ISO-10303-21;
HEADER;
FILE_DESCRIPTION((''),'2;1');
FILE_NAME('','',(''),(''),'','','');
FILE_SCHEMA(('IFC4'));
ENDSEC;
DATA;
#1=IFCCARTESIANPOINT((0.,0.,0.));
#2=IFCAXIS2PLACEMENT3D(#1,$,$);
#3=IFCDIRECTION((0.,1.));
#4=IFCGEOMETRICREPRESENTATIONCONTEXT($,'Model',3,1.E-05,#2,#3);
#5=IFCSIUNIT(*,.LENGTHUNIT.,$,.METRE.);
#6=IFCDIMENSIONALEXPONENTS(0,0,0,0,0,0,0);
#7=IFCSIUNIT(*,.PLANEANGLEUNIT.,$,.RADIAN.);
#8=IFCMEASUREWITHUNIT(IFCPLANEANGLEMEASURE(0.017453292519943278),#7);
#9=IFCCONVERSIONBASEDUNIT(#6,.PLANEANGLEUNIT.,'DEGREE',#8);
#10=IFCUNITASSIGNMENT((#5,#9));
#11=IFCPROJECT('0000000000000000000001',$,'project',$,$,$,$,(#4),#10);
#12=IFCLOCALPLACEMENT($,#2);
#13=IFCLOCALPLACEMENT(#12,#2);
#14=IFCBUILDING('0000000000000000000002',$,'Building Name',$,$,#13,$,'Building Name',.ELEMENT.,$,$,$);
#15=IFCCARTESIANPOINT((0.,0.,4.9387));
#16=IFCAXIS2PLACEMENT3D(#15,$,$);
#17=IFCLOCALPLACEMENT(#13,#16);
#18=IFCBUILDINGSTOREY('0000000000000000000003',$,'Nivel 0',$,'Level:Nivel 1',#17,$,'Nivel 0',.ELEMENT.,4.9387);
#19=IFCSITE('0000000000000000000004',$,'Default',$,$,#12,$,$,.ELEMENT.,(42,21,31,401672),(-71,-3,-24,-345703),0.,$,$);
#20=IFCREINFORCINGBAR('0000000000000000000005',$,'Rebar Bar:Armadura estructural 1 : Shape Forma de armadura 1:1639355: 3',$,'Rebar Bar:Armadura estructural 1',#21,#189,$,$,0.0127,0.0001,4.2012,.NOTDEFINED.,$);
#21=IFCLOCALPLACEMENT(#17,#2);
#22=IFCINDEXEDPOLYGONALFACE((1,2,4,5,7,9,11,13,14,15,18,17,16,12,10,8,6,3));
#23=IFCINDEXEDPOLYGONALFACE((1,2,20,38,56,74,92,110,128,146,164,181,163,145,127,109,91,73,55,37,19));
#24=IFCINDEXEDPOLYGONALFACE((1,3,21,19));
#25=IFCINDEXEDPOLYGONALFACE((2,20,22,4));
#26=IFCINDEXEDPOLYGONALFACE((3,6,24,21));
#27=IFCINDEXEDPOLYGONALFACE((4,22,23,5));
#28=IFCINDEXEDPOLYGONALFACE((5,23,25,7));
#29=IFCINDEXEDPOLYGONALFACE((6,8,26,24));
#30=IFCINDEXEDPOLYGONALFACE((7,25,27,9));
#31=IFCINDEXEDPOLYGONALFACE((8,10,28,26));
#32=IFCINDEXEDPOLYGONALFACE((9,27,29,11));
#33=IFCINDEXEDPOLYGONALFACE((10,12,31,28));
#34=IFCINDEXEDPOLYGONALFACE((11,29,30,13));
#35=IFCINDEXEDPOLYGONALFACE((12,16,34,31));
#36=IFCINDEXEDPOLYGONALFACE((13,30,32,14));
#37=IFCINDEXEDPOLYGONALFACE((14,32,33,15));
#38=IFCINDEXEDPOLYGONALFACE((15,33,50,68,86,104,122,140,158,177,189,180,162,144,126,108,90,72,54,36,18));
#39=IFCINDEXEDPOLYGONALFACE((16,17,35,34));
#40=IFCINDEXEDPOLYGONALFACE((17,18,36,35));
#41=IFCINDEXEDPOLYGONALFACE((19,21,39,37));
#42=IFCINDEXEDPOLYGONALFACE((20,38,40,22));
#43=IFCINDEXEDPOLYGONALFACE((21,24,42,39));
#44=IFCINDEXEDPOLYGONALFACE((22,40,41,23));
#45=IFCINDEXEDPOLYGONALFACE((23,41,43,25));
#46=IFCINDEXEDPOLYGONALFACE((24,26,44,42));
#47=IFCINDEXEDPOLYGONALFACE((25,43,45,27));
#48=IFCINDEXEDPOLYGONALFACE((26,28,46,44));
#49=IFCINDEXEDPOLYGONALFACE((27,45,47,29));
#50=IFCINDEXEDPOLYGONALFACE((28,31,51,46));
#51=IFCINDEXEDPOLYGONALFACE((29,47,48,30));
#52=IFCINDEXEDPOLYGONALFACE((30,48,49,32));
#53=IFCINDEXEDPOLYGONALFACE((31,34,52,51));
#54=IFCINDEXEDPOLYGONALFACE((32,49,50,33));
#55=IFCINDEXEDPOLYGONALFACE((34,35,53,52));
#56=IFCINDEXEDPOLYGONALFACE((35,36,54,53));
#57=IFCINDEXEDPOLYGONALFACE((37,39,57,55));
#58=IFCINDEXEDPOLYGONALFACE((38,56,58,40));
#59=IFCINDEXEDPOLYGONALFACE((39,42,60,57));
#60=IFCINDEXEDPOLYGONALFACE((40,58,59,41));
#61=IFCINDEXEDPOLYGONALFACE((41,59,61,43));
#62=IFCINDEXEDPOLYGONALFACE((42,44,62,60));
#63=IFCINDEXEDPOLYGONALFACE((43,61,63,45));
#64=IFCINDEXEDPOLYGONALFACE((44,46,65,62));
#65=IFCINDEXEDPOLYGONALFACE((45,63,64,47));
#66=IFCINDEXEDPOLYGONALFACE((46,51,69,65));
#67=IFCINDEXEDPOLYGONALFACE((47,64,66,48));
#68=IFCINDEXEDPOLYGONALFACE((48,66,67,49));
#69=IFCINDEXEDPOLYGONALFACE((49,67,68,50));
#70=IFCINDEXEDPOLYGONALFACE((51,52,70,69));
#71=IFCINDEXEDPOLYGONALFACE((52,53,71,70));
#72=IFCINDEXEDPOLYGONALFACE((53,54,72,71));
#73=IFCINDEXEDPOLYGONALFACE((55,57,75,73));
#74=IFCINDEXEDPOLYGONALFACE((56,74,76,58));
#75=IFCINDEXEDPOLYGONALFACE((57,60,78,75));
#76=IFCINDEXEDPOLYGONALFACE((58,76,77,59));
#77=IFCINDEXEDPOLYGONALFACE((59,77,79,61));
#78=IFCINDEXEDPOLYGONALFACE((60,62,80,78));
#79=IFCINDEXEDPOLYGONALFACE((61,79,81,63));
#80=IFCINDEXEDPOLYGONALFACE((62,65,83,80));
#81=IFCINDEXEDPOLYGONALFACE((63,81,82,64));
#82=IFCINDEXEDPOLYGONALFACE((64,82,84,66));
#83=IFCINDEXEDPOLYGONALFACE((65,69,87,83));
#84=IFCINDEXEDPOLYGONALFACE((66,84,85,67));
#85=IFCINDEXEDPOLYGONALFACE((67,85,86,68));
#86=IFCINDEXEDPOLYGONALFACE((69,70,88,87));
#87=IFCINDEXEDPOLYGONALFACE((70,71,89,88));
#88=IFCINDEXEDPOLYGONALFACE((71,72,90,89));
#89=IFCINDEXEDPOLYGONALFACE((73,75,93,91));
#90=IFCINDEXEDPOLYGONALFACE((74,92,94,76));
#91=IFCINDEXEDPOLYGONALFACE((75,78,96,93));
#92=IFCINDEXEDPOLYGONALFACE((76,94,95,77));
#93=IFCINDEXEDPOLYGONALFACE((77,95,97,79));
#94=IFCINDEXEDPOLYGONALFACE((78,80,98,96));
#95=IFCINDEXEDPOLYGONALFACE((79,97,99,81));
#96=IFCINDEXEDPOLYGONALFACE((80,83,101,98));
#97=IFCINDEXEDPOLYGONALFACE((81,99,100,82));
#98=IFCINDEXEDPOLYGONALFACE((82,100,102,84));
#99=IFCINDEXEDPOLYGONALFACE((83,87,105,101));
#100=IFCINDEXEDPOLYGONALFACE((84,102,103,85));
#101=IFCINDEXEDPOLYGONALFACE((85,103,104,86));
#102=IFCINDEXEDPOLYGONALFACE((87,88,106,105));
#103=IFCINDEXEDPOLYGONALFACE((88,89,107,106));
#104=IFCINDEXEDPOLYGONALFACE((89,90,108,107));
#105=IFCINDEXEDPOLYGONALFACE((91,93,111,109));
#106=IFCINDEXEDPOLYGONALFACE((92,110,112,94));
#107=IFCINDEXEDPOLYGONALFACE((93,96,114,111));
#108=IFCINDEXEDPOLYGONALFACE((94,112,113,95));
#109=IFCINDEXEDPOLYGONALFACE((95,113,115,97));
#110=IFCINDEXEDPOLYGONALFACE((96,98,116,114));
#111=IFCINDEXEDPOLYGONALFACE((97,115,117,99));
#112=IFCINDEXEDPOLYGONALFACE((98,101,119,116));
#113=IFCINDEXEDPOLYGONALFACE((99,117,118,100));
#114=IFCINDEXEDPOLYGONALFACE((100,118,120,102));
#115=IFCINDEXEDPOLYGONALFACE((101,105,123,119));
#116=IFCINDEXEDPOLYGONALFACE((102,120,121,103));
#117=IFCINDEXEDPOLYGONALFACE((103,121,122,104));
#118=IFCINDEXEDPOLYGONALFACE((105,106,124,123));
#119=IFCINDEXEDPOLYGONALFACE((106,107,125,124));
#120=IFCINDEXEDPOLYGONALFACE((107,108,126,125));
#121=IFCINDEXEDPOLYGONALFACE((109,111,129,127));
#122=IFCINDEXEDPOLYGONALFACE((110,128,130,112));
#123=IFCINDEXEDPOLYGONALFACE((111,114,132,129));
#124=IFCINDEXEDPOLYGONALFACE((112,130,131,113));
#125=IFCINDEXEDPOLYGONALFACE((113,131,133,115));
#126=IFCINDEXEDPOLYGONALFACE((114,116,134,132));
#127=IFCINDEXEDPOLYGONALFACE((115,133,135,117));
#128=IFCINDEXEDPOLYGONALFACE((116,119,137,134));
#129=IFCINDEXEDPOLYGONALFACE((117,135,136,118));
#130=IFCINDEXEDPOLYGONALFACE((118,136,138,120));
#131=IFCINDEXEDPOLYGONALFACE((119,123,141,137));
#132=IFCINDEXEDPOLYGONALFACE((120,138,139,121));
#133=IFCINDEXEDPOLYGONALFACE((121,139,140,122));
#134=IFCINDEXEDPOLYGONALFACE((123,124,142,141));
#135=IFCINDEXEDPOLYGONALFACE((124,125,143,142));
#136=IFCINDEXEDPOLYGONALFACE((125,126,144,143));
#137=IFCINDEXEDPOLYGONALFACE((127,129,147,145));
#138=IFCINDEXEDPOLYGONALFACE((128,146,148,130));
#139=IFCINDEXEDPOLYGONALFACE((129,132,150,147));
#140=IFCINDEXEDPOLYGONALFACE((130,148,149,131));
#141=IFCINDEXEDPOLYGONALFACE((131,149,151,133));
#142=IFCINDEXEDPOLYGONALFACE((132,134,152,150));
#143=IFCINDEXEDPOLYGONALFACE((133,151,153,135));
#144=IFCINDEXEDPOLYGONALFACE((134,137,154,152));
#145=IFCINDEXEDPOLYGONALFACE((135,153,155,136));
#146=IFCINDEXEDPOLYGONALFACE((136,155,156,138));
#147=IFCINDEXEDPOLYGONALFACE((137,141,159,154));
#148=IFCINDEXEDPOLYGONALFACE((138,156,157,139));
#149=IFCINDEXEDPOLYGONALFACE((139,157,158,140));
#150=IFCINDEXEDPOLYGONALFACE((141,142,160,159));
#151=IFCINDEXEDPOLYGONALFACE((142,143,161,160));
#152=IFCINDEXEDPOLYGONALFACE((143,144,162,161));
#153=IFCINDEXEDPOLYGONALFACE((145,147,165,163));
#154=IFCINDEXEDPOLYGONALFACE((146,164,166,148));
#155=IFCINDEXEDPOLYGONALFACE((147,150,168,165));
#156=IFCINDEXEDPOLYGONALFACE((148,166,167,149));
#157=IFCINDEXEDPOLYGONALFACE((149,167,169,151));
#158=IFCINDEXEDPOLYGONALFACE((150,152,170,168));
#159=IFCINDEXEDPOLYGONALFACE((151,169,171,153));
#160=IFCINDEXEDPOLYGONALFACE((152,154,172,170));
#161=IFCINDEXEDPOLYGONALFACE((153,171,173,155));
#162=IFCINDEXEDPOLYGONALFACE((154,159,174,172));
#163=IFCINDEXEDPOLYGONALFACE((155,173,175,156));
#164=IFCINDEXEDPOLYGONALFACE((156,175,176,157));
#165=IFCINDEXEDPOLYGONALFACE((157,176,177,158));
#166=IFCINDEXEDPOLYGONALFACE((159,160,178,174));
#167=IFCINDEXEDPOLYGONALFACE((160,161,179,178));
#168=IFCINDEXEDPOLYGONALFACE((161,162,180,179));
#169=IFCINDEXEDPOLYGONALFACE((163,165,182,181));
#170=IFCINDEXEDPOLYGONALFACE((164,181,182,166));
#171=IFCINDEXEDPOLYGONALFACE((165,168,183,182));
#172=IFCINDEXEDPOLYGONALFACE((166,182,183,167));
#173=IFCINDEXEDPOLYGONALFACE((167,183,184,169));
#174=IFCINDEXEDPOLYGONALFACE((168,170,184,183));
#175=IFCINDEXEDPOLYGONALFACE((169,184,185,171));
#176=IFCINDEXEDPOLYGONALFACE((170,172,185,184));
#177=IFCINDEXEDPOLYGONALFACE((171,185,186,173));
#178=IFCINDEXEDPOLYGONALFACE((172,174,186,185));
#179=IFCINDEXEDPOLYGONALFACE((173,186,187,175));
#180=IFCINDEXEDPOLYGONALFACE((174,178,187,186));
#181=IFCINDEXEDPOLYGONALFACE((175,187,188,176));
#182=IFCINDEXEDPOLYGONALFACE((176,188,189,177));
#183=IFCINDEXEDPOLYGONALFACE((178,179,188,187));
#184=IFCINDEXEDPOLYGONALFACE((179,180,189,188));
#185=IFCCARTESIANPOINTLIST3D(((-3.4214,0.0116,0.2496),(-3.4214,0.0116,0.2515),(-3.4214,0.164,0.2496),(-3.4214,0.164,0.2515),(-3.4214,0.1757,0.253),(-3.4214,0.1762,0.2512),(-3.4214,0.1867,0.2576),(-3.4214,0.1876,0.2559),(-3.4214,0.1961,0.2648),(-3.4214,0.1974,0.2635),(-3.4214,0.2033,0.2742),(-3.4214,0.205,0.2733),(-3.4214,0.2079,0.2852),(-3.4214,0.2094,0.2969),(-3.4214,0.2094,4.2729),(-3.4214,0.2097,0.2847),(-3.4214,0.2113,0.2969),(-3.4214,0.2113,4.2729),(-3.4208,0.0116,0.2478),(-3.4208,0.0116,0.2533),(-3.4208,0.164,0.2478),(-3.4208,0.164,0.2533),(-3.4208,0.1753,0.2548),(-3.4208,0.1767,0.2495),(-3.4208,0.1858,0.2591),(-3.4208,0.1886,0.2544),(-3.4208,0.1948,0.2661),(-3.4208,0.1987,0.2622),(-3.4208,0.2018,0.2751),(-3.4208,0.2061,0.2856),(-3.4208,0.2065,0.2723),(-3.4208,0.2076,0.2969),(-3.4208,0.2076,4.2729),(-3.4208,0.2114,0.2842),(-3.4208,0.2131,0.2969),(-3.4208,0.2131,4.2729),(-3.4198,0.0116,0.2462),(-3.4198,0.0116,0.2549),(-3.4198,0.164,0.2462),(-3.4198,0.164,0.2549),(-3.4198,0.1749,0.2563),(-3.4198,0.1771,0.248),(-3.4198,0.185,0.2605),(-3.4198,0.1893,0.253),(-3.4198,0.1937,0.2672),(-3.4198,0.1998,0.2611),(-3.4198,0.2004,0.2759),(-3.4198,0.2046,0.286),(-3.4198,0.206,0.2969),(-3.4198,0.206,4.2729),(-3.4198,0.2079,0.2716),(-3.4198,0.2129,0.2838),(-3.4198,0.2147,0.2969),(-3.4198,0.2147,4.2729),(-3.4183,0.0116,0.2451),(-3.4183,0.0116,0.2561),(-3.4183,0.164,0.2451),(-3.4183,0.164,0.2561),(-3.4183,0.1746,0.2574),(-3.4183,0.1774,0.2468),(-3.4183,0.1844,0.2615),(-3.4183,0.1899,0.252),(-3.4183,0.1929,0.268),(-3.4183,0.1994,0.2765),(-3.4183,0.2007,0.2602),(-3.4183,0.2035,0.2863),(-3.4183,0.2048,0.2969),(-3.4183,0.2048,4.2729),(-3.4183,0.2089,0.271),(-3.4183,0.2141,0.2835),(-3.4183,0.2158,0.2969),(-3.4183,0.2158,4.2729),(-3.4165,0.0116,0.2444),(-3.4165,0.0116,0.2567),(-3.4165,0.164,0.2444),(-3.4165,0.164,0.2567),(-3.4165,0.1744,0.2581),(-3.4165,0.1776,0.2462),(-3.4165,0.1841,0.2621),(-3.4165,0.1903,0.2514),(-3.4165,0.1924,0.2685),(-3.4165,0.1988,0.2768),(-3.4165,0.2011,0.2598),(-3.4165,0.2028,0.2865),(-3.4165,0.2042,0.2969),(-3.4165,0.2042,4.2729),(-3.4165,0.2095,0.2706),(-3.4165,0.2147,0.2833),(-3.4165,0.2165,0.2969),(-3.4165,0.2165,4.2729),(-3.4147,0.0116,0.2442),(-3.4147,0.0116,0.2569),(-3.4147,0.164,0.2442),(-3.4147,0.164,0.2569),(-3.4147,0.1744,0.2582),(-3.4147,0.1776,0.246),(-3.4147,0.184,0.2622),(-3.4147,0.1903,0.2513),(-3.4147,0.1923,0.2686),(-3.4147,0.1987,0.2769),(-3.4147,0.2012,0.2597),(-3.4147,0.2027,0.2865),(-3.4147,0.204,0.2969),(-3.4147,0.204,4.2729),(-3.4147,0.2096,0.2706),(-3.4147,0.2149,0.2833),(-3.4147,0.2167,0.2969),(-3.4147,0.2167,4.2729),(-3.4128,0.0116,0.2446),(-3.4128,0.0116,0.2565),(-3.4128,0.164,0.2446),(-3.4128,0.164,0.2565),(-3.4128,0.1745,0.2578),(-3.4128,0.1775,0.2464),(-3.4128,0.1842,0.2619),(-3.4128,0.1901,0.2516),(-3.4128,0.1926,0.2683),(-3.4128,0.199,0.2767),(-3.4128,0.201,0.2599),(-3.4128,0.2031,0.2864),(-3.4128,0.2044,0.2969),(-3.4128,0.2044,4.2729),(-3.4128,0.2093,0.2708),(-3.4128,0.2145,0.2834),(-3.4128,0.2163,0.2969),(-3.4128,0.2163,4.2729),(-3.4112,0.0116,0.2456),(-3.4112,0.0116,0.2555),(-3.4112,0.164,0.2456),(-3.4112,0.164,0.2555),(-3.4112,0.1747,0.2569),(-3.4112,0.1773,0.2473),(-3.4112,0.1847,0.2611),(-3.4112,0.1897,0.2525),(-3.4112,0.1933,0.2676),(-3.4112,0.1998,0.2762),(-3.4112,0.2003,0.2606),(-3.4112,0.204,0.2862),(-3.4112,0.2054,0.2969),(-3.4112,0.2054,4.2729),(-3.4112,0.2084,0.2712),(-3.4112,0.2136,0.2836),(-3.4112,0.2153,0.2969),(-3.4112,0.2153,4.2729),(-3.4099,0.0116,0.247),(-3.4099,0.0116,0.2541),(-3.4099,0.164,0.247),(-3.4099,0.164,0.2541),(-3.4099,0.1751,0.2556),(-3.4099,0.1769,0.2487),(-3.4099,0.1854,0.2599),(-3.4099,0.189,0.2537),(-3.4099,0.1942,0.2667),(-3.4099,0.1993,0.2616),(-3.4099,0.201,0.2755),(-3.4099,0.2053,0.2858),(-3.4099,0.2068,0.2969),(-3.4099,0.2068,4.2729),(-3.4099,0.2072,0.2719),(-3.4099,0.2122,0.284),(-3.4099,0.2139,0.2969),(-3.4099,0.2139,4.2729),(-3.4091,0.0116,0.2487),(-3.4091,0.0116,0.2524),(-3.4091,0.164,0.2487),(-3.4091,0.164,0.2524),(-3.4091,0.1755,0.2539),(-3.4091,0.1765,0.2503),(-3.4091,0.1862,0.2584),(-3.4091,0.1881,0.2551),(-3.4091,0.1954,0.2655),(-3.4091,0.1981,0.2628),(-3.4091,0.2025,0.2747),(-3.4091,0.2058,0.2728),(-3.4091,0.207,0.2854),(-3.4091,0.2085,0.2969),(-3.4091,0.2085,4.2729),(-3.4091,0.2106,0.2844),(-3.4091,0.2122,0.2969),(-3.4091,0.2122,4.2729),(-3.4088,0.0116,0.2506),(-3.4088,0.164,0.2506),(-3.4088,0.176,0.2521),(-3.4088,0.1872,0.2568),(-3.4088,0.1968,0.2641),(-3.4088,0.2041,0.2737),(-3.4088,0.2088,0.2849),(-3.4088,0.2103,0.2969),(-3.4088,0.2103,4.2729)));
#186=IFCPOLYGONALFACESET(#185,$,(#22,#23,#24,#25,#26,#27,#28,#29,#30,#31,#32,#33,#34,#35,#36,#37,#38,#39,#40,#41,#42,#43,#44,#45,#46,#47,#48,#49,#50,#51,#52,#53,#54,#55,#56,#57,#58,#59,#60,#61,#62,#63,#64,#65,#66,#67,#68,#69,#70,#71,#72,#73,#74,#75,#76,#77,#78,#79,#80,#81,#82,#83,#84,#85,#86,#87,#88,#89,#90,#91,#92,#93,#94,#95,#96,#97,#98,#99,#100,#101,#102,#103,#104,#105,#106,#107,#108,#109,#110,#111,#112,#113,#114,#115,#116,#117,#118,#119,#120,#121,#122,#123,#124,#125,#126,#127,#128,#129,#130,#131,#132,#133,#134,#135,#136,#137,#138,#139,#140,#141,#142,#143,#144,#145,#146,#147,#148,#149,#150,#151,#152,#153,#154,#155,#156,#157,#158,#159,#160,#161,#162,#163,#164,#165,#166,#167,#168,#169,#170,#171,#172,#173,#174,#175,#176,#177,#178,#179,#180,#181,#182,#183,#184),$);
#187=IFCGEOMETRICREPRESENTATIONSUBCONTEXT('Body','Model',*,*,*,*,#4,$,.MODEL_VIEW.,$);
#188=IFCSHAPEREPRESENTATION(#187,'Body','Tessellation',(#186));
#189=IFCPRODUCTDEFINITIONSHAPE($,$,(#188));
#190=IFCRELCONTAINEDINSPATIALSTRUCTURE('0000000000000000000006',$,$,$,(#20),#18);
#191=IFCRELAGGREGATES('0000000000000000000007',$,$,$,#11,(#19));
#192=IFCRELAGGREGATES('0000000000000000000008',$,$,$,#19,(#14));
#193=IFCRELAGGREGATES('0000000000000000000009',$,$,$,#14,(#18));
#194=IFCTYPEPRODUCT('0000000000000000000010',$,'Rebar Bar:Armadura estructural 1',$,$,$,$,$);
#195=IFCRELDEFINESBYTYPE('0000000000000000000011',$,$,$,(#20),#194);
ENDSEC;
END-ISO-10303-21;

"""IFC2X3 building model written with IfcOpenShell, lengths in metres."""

from ifc_helpers import new_model, entity, si_unit, converted_unit, direction, frame, origin, place, context, subcontext, project, spatial, type_object, element, save


model = new_model("IFC2X3")

# Units and contexts
model_context = context("Model", 3, precision=1e-05, world=origin(), true_north=direction((0.0, 1.0)))
body_context = subcontext(model_context, "Body", "Model", "MODEL_VIEW")
ifc_project = project(units=[si_unit("LENGTHUNIT", "METRE"), converted_unit("PLANEANGLEUNIT", "DEGREE", entity("IfcPlaneAngleMeasure", 0.017453292519943278), si_unit("PLANEANGLEUNIT", "RADIAN"), dimensions=[0, 0, 0, 0, 0, 0, 0])], contexts=[model_context])

# Site, building, storey
site_placement = place(None, origin())
site = spatial("IfcSite", under=ifc_project, at=site_placement, Name="Default", CompositionType="ELEMENT", RefLatitude=(42, 21, 31, 401672), RefLongitude=(-71, -3, -24, -345703), RefElevation=0.0)
building_placement = place(site_placement, origin())
building = spatial("IfcBuilding", under=site, at=building_placement, Name="Building Name", LongName="Building Name", CompositionType="ELEMENT")
storey_placement = place(building_placement, frame((0.0, 0.0, 4.9387)))
storey = spatial("IfcBuildingStorey", under=building, at=storey_placement, Name="Nivel 0", ObjectType="Level:Nivel 1", LongName="Nivel 0", CompositionType="ELEMENT", Elevation=4.9387)

# Reinforcing bar
type_product = type_object("IfcTypeProduct", Name="Rebar Bar:Armadura estructural 1")
reinforcing_bar_1_placement = place(storey_placement, origin())
element("IfcReinforcingBar", 1, at=reinforcing_bar_1_placement, inside=storey, type_object=type_product, Name="Rebar Bar:Armadura estructural 1 : Shape Forma de armadura 1:1639355: 3", ObjectType="Rebar Bar:Armadura estructural 1", BarLength=4.2012, BarRole="NOTDEFINED", CrossSectionArea=0.0001, NominalDiameter=0.0127, context=body_context, shape_type="AdvancedSweptSolid", body=[
    entity("IfcSweptDiskSolid", entity("IfcCompositeCurve", [entity("IfcCompositeCurveSegment", "CONTINUOUS", True, entity("IfcPolyline", [entity("IfcCartesianPoint", [-3.4151, 0.0116, 0.2506]), entity("IfcCartesianPoint", [-3.4151, 0.164, 0.2506])])), entity("IfcCompositeCurveSegment", "CONTINUOUS", True, entity("IfcTrimmedCurve", entity("IfcCircle", entity("IfcAxis2Placement3D", entity("IfcCartesianPoint", [-3.4151, 0.164, 0.2969]), entity("IfcDirection", [1.0, 0.0, 0.0]), entity("IfcDirection", [0.0, 1.0, 0.0])), 0.0464), [entity("IfcParameterValue", 270.0)], [entity("IfcParameterValue", 360.0)], True, "PARAMETER")), entity("IfcCompositeCurveSegment", "CONTINUOUS", True, entity("IfcPolyline", [entity("IfcCartesianPoint", [-3.4151, 0.2103, 0.2969]), entity("IfcCartesianPoint", [-3.4151, 0.2103, 4.2729])]))], False), 0.0063, None, 0.0, 92.0),
])

save(model, "model.ifc")
